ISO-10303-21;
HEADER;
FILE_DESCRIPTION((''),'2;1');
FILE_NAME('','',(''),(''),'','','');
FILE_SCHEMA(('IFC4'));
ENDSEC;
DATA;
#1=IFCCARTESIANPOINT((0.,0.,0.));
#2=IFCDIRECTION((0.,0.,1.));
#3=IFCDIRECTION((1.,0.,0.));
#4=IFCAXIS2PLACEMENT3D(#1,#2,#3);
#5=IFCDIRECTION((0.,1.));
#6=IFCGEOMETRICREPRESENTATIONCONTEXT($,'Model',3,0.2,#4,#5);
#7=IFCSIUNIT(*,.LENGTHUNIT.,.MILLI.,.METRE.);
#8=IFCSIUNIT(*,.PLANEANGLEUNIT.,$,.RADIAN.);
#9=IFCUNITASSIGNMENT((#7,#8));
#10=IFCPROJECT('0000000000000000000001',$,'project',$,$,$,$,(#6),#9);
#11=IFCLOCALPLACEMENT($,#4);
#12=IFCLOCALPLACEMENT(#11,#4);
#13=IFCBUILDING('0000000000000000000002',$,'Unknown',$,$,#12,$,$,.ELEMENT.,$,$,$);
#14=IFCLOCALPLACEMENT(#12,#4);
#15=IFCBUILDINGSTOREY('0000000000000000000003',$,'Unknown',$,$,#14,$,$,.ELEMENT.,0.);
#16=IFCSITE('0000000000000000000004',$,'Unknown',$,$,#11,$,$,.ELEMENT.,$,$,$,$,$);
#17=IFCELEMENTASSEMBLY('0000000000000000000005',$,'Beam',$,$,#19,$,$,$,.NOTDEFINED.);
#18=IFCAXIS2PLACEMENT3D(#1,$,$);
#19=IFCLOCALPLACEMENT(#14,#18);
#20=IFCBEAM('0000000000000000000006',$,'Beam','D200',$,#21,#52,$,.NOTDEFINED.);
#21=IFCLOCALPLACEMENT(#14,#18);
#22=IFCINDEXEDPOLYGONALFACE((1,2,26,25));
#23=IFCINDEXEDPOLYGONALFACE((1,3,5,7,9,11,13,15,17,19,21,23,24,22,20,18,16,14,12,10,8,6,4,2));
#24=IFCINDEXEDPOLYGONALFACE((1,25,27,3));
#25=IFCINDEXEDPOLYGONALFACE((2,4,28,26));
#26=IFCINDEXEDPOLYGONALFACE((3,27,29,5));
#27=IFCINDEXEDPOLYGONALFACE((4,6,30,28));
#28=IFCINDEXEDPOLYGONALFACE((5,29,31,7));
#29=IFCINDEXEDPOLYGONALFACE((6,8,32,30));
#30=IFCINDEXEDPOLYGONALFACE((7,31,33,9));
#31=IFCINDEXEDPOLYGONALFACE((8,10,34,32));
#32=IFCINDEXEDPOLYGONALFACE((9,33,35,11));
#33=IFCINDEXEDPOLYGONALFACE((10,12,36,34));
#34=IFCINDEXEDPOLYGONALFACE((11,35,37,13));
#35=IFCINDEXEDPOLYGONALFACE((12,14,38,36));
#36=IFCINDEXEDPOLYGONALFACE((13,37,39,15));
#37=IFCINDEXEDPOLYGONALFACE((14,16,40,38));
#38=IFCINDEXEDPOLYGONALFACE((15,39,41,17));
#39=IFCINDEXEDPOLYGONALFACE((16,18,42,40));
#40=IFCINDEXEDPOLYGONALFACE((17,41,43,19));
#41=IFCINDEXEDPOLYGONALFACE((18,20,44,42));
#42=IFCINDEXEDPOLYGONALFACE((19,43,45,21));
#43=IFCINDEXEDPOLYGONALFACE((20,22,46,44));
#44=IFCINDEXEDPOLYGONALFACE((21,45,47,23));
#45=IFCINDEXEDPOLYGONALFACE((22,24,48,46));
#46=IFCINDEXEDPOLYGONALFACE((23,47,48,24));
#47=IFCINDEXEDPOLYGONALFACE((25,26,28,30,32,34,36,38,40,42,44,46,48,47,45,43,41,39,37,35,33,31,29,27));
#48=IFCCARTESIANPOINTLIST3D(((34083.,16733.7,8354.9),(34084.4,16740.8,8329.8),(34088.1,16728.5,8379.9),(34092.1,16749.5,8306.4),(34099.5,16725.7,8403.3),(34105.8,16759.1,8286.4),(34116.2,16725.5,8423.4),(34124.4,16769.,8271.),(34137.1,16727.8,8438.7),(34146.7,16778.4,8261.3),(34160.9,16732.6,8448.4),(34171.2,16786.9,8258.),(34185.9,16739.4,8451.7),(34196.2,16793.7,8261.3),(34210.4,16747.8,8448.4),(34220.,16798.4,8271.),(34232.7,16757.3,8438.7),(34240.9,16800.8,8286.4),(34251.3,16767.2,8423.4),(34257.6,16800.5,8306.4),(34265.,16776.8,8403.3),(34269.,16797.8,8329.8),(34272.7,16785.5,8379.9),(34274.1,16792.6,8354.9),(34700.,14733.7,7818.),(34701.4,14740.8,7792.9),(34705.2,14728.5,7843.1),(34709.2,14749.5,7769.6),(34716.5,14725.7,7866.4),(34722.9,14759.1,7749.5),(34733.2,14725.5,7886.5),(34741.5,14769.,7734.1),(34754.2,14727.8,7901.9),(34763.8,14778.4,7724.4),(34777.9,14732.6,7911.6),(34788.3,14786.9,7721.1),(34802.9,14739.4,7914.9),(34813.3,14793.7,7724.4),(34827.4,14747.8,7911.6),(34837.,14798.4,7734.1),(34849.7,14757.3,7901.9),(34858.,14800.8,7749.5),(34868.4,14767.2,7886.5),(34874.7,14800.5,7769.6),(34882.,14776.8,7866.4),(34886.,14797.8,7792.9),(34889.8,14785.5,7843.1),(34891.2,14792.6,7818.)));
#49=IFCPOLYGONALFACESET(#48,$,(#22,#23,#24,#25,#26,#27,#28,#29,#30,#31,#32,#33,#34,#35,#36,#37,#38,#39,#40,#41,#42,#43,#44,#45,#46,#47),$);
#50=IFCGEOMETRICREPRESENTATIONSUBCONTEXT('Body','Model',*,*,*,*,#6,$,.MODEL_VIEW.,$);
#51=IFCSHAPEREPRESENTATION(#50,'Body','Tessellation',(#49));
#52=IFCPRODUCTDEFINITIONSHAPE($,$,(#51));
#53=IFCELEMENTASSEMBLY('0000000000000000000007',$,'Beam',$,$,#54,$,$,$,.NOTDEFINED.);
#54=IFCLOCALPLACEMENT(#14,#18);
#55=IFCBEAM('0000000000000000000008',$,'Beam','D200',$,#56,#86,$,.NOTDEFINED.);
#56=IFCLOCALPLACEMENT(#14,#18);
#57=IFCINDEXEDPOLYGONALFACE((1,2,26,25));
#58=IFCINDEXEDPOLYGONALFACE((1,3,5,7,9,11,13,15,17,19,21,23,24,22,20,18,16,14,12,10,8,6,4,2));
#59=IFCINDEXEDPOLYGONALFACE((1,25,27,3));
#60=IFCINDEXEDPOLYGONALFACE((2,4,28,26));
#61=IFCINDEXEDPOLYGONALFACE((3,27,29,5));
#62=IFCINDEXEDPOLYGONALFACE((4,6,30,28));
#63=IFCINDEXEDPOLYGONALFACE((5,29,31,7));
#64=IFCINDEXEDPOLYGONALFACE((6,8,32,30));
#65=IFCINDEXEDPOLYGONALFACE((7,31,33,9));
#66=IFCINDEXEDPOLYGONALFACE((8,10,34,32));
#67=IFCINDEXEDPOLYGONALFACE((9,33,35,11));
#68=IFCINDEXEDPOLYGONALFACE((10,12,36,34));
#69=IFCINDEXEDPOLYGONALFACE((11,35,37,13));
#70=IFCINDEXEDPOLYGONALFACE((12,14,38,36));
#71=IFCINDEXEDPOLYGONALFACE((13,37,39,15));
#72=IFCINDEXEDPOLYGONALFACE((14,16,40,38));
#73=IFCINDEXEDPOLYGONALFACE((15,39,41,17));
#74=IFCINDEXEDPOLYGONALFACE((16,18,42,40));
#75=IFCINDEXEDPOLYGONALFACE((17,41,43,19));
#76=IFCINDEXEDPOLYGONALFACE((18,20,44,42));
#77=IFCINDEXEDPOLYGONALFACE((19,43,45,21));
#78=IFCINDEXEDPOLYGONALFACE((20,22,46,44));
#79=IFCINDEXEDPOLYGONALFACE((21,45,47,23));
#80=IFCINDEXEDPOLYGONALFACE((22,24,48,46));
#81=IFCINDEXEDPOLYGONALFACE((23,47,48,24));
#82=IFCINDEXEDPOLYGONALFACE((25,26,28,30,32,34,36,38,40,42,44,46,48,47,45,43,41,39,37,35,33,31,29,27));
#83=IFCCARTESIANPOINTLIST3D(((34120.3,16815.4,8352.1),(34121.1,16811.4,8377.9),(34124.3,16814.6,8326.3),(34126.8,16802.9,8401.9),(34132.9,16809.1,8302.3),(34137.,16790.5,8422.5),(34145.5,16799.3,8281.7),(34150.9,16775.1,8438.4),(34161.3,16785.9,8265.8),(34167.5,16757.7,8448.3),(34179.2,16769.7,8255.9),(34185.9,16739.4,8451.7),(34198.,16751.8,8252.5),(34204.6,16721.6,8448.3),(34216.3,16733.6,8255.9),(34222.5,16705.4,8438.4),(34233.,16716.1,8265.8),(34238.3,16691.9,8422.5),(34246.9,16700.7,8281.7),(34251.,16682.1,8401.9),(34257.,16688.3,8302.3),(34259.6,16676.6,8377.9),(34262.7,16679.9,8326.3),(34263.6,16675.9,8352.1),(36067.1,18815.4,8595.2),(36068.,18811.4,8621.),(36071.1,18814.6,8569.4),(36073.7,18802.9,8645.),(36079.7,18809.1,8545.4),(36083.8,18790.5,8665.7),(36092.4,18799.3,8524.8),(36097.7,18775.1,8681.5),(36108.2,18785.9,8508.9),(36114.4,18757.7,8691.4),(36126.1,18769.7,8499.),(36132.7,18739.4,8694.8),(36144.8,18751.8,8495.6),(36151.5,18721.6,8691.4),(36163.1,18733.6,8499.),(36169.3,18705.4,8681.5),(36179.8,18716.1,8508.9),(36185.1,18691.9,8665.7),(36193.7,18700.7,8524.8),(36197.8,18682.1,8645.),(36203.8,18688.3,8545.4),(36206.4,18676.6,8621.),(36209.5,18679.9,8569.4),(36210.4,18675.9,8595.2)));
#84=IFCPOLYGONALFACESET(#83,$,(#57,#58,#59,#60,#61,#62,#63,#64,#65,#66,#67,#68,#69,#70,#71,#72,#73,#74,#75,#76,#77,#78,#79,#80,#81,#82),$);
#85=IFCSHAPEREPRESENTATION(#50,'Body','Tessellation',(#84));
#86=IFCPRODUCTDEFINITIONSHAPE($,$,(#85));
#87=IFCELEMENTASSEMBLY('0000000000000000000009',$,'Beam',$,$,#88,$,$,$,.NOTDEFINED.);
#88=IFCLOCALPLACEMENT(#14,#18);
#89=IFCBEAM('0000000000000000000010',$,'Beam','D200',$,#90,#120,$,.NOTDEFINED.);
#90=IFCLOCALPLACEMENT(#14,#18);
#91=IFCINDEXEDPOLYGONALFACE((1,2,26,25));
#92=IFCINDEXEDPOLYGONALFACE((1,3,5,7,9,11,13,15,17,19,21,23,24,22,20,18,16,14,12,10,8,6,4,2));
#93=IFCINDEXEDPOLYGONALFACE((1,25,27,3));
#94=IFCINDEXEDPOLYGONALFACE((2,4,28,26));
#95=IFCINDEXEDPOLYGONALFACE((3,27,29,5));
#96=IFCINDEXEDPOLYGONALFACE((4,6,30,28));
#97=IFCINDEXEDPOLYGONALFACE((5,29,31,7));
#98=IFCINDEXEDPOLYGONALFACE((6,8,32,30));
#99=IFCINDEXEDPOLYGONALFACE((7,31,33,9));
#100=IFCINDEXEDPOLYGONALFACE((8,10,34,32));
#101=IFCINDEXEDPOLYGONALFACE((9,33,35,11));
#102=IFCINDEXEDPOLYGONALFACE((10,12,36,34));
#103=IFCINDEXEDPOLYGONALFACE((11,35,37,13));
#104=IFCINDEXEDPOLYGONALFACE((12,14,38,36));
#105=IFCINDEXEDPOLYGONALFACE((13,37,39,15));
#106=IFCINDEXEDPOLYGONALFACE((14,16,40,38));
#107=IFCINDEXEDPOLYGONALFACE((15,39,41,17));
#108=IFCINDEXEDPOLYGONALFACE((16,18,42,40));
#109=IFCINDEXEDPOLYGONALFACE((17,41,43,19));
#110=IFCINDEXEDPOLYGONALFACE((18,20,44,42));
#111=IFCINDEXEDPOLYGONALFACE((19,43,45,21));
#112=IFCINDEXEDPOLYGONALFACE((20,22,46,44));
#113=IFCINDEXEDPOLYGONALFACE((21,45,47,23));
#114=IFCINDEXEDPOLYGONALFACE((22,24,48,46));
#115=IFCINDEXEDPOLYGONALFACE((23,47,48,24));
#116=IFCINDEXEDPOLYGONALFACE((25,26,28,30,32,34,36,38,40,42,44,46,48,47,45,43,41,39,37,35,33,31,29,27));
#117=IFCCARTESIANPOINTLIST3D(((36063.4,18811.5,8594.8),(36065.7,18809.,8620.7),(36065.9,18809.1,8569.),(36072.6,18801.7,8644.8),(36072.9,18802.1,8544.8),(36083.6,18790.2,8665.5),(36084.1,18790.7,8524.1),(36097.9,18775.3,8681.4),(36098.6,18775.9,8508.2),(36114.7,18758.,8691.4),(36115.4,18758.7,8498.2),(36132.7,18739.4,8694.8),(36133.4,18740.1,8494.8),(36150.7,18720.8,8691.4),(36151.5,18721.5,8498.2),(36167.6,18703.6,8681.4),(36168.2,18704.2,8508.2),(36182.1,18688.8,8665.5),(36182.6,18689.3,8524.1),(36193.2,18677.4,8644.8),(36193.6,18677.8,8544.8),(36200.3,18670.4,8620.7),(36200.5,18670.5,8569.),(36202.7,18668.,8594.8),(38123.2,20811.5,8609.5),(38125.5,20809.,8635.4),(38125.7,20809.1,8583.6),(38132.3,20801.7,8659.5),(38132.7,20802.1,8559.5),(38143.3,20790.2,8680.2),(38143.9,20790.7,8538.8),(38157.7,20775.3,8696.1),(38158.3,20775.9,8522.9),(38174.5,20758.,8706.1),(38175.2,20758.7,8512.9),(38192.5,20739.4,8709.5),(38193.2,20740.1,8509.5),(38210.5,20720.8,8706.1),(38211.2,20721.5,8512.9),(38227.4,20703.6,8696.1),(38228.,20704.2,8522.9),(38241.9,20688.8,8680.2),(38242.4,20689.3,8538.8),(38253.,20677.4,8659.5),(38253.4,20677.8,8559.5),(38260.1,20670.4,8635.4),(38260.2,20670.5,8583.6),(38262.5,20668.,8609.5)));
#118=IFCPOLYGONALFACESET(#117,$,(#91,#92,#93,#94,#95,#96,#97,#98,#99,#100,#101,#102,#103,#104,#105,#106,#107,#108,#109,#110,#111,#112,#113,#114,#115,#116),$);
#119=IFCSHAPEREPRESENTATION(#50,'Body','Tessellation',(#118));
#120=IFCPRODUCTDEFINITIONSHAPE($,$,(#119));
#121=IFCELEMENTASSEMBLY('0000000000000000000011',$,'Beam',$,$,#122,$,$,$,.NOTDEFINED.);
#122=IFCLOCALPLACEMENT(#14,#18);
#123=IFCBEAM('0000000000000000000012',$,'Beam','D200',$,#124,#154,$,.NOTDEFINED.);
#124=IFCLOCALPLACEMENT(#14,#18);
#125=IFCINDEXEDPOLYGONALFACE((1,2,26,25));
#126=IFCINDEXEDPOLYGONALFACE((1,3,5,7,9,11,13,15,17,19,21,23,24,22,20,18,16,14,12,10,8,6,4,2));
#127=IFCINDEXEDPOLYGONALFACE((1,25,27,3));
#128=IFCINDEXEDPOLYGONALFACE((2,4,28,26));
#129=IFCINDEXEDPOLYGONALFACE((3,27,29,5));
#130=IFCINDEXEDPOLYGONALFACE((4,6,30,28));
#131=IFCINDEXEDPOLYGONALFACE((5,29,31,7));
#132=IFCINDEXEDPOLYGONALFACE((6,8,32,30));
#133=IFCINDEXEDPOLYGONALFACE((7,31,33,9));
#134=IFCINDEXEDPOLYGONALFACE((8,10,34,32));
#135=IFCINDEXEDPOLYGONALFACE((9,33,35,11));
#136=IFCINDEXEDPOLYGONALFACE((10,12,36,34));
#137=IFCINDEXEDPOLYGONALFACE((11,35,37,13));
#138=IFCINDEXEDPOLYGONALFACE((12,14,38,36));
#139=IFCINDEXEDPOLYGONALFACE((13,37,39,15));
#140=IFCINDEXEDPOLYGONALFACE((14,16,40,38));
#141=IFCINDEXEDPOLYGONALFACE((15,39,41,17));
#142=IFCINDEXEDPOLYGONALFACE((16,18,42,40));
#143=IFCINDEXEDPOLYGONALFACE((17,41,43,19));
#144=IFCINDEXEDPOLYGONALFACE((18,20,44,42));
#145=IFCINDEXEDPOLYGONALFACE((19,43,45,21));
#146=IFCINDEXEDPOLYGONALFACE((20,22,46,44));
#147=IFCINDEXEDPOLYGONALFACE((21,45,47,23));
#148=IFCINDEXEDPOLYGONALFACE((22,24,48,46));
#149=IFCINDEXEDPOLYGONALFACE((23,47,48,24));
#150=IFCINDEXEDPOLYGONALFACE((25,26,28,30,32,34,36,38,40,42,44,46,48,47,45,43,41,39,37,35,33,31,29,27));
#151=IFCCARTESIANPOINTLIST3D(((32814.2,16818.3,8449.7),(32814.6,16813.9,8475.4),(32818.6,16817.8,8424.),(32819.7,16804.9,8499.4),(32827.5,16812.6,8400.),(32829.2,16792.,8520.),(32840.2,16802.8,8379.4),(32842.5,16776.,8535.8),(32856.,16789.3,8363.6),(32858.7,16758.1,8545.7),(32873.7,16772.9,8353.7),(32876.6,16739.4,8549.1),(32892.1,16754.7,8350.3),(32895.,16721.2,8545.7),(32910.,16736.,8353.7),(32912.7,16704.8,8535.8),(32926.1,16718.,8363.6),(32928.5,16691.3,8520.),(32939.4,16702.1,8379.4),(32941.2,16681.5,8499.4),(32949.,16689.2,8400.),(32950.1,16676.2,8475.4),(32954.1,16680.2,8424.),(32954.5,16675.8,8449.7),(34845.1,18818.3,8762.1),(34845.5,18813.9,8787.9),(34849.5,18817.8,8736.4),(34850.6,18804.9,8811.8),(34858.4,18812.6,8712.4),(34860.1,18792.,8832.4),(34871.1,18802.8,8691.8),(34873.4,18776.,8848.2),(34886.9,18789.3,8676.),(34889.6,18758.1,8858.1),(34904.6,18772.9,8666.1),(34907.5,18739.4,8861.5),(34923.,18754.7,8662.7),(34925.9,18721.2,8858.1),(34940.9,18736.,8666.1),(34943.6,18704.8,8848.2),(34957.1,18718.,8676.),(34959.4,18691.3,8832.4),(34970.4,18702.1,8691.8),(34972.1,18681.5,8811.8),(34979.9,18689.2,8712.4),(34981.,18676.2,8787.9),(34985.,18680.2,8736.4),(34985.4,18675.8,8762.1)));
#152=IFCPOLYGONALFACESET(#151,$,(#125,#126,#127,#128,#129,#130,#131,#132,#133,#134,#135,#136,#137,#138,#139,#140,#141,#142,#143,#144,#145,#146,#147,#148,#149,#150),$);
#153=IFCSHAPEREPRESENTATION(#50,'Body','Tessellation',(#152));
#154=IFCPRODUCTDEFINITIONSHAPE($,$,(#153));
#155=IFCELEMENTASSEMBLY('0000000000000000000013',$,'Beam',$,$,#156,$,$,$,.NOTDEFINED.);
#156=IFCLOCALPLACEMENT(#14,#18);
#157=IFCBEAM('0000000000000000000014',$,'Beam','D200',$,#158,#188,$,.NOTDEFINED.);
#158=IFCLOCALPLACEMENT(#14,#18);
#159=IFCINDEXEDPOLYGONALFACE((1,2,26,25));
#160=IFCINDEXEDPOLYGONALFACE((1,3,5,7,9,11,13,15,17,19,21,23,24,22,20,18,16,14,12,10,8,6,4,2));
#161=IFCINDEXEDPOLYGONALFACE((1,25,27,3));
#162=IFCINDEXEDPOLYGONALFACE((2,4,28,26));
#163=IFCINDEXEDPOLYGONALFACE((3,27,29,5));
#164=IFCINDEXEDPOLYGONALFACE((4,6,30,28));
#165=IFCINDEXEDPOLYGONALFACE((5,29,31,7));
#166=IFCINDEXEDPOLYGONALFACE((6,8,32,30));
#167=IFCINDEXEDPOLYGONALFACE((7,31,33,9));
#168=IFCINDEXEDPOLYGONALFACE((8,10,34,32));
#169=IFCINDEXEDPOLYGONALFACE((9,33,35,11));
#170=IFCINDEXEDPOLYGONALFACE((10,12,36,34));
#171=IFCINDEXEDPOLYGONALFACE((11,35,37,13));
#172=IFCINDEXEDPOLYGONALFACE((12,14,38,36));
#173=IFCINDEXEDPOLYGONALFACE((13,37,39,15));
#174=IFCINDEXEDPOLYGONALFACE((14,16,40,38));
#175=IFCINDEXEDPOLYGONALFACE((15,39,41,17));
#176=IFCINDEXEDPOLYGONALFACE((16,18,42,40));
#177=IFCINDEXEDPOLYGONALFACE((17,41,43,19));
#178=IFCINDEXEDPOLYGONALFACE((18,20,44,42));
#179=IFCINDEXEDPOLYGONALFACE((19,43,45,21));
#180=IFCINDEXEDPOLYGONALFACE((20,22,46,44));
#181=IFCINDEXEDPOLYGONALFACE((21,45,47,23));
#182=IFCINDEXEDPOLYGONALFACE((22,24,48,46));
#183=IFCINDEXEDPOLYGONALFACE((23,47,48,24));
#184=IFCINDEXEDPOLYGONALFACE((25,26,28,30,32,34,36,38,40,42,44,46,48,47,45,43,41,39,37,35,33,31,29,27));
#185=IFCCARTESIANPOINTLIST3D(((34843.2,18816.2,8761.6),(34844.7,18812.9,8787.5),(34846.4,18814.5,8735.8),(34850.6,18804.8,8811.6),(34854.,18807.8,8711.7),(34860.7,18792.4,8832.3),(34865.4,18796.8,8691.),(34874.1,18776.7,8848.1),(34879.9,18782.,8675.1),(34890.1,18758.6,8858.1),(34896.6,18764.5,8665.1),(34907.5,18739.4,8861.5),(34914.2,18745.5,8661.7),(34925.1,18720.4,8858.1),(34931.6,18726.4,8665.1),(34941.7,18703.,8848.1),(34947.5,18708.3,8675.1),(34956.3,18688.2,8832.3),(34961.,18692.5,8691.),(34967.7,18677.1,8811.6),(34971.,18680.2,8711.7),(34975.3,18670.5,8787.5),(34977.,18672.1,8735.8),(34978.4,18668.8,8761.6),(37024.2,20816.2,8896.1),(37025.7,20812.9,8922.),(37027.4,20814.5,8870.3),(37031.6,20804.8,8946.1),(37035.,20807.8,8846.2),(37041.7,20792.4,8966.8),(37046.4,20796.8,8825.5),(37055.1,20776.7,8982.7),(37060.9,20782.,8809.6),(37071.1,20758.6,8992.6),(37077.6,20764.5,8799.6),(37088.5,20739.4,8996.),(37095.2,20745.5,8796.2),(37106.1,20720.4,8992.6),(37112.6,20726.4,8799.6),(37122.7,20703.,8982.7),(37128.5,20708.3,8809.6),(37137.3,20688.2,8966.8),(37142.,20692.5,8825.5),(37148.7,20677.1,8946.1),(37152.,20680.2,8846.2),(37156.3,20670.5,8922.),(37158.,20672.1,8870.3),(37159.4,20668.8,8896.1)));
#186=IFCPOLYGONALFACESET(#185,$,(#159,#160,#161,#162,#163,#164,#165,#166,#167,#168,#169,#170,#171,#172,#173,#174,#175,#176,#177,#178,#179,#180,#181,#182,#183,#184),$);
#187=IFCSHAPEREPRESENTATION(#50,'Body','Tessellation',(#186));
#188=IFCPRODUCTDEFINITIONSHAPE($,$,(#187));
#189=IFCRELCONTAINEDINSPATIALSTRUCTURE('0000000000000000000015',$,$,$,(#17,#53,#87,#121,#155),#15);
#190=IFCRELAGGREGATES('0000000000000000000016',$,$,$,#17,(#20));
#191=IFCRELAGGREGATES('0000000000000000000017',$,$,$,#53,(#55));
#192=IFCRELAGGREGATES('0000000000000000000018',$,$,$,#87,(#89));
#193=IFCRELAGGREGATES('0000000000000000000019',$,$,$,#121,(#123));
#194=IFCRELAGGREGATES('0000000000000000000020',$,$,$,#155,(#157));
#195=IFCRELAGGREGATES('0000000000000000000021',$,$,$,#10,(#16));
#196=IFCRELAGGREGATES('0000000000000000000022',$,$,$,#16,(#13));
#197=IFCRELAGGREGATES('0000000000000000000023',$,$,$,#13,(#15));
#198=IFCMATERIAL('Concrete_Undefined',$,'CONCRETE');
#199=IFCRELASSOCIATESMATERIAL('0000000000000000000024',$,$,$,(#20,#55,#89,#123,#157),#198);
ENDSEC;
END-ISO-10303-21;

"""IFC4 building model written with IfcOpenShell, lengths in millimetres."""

from ifc_helpers import new_model, si_unit, direction, frame, origin_with_axes, place, context, subcontext, project, spatial, line, indexed_curve, outline, extrude, material, element, aggregate, save


model = new_model("IFC4")

# Units and contexts
model_context = context("Model", 3, precision=0.2, world=origin_with_axes(), true_north=direction((0.0, 1.0)))
body_context = subcontext(model_context, "Body", "Model", "MODEL_VIEW")
ifc_project = project(units=[si_unit("LENGTHUNIT", "METRE", prefix="MILLI"), si_unit("PLANEANGLEUNIT", "RADIAN")], contexts=[model_context])

# Site, building, storey
site_placement = place(None, origin_with_axes())
site = spatial("IfcSite", under=ifc_project, at=site_placement, Name="Unknown", CompositionType="ELEMENT")
building_placement = place(site_placement, origin_with_axes())
building = spatial("IfcBuilding", under=site, at=building_placement, Name="Unknown", CompositionType="ELEMENT")
storey_placement = place(building_placement, origin_with_axes())
storey = spatial("IfcBuildingStorey", under=building, at=storey_placement, Name="Unknown", CompositionType="ELEMENT", Elevation=0.0)

# Element assemblies, beams
ifc_material = material(Name="Concrete_Undefined", Category="CONCRETE")
assembly_1_placement = place(storey_placement, frame((34178.6, 16763.1, 8354.9), z_axis=(-0.955555, -0.294814, 0.0), x_axis=(0.28557, -0.925591, -0.248458)))
assembly_1 = element("IfcElementAssembly", 1, at=assembly_1_placement, inside=storey, Name="Beam", PredefinedType="NOTDEFINED")
beam_1_placement = place(assembly_1_placement, origin_with_axes())
beam_1 = element("IfcBeam", 2, at=beam_1_placement, material=ifc_material, Name="Beam", Description="D200", PredefinedType="NOTDEFINED", context=body_context, shape_type="SolidModel", body=[
    extrude(outline(indexed_curve([(100.0, 0.0), (96.6, 25.9), (86.6, 50.0), (70.7, 70.7), (50.0, 86.6), (25.9, 96.6), (0.0, 100.0), (-25.9, 96.6), (-50.0, 86.6), (-70.7, 70.7), (-86.6, 50.0), (-96.6, 25.9), (-100.0, 0.0), (-96.6, -25.9), (-86.6, -50.0), (-70.7, -70.7), (-50.0, -86.6), (-25.9, -96.6), (0.0, -100.0), (25.9, -96.6), (50.0, -86.6), (70.7, -70.7), (86.6, -50.0), (96.6, -25.9)], segments=[line(1, 2, 3, 4, 5, 6, 7, 8, 9, 10, 11, 12, 13, 14, 15, 16, 17, 18, 19, 20, 21, 22, 23, 24, 1)])), frame((0.0, 0.0, 0.0), z_axis=(-1.0, 0.0, 0.0), x_axis=(0.0, 0.0, 1.0)), (0.0, 0.0, -1.0), 2160.8),
])
aggregate(assembly_1, [beam_1])
assembly_2_placement = place(storey_placement, frame((36138.8, 18745.6, 8595.2), z_axis=(-0.716568, 0.697517, 0.0), x_axis=(-0.694886, -0.713866, -0.086774)))
assembly_2 = element("IfcElementAssembly", 3, at=assembly_2_placement, inside=storey, Name="Beam", PredefinedType="NOTDEFINED")
beam_2_placement = place(assembly_2_placement, origin_with_axes())
beam_2 = element("IfcBeam", 4, at=beam_2_placement, material=ifc_material, Name="Beam", Description="D200", PredefinedType="NOTDEFINED", context=body_context, shape_type="SolidModel", body=[
    extrude(outline(indexed_curve([(100.0, 0.0), (96.6, 25.9), (86.6, 50.0), (70.7, 70.7), (50.0, 86.6), (25.9, 96.6), (0.0, 100.0), (-25.9, 96.6), (-50.0, 86.6), (-70.7, 70.7), (-86.6, 50.0), (-96.6, 25.9), (-100.0, 0.0), (-96.6, -25.9), (-86.6, -50.0), (-70.7, -70.7), (-50.0, -86.6), (-25.9, -96.6), (0.0, -100.0), (25.9, -96.6), (50.0, -86.6), (70.7, -70.7), (86.6, -50.0), (96.6, -25.9)], segments=[line(1, 2, 3, 4, 5, 6, 7, 8, 9, 10, 11, 12, 13, 14, 15, 16, 17, 18, 19, 20, 21, 22, 23, 24, 1)])), frame((0.0, 0.0, 0.0), z_axis=(-1.0, 0.0, 0.0), x_axis=(0.0, 0.0, 1.0)), (0.0, 0.0, -1.0), 2801.6),
])
aggregate(assembly_2, [beam_2])
assembly_3_placement = place(storey_placement, frame((38192.9, 20739.8, 8609.5), z_axis=(-0.696617, 0.717443, 0.0), x_axis=(-0.717434, -0.696608, -0.005114)))
assembly_3 = element("IfcElementAssembly", 5, at=assembly_3_placement, inside=storey, Name="Beam", PredefinedType="NOTDEFINED")
beam_3_placement = place(assembly_3_placement, origin_with_axes())
beam_3 = element("IfcBeam", 6, at=beam_3_placement, material=ifc_material, Name="Beam", Description="D200", PredefinedType="NOTDEFINED", context=body_context, shape_type="SolidModel", body=[
    extrude(outline(indexed_curve([(100.0, 0.0), (96.6, 25.9), (86.6, 50.0), (70.7, 70.7), (50.0, 86.6), (25.9, 96.6), (0.0, 100.0), (-25.9, 96.6), (-50.0, 86.6), (-70.7, 70.7), (-86.6, 50.0), (-96.6, 25.9), (-100.0, 0.0), (-96.6, -25.9), (-86.6, -50.0), (-70.7, -70.7), (-50.0, -86.6), (-25.9, -96.6), (0.0, -100.0), (25.9, -96.6), (50.0, -86.6), (70.7, -70.7), (86.6, -50.0), (96.6, -25.9)], segments=[line(1, 2, 3, 4, 5, 6, 7, 8, 9, 10, 11, 12, 13, 14, 15, 16, 17, 18, 19, 20, 21, 22, 23, 24, 1)])), frame((0.0, 0.0, 0.0), z_axis=(-1.0, 0.0, 0.0), x_axis=(0.0, 0.0, 1.0)), (0.0, 0.0, -1.0), 2871.1),
])
aggregate(assembly_3, [beam_3])
assembly_4_placement = place(storey_placement, frame((34915.3, 18747.0, 8762.1), z_axis=(-0.701663, 0.712509, 0.0), x_axis=(-0.708267, -0.697486, -0.108952)))
assembly_4 = element("IfcElementAssembly", 7, at=assembly_4_placement, inside=storey, Name="Beam", PredefinedType="NOTDEFINED")
beam_4_placement = place(assembly_4_placement, origin_with_axes())
beam_4 = element("IfcBeam", 8, at=beam_4_placement, material=ifc_material, Name="Beam", Description="D200", PredefinedType="NOTDEFINED", context=body_context, shape_type="SolidModel", body=[
    extrude(outline(indexed_curve([(100.0, 0.0), (96.6, 25.9), (86.6, 50.0), (70.7, 70.7), (50.0, 86.6), (25.9, 96.6), (0.0, 100.0), (-25.9, 96.6), (-50.0, 86.6), (-70.7, 70.7), (-86.6, 50.0), (-96.6, 25.9), (-100.0, 0.0), (-96.6, -25.9), (-86.6, -50.0), (-70.7, -70.7), (-50.0, -86.6), (-25.9, -96.6), (0.0, -100.0), (25.9, -96.6), (50.0, -86.6), (70.7, -70.7), (86.6, -50.0), (96.6, -25.9)], segments=[line(1, 2, 3, 4, 5, 6, 7, 8, 9, 10, 11, 12, 13, 14, 15, 16, 17, 18, 19, 20, 21, 22, 23, 24, 1)])), frame((0.0, 0.0, 0.0), z_axis=(-1.0, 0.0, 0.0), x_axis=(0.0, 0.0, 1.0)), (0.0, 0.0, -1.0), 2867.4),
])
aggregate(assembly_4, [beam_4])
assembly_5_placement = place(storey_placement, frame((37091.8, 20742.5, 8896.1), z_axis=(-0.675863, 0.737028, 0.0), x_axis=(-0.736267, -0.675166, -0.045407)))
assembly_5 = element("IfcElementAssembly", 9, at=assembly_5_placement, inside=storey, Name="Beam", PredefinedType="NOTDEFINED")
beam_5_placement = place(assembly_5_placement, origin_with_axes())
beam_5 = element("IfcBeam", 10, at=beam_5_placement, material=ifc_material, Name="Beam", Description="D200", PredefinedType="NOTDEFINED", context=body_context, shape_type="SolidModel", body=[
    extrude(outline(indexed_curve([(100.0, 0.0), (96.6, 25.9), (86.6, 50.0), (70.7, 70.7), (50.0, 86.6), (25.9, 96.6), (0.0, 100.0), (-25.9, 96.6), (-50.0, 86.6), (-70.7, 70.7), (-86.6, 50.0), (-96.6, 25.9), (-100.0, 0.0), (-96.6, -25.9), (-86.6, -50.0), (-70.7, -70.7), (-50.0, -86.6), (-25.9, -96.6), (0.0, -100.0), (25.9, -96.6), (50.0, -86.6), (70.7, -70.7), (86.6, -50.0), (96.6, -25.9)], segments=[line(1, 2, 3, 4, 5, 6, 7, 8, 9, 10, 11, 12, 13, 14, 15, 16, 17, 18, 19, 20, 21, 22, 23, 24, 1)])), frame((0.0, 0.0, 0.0), z_axis=(-1.0, 0.0, 0.0), x_axis=(0.0, 0.0, 1.0)), (0.0, 0.0, -1.0), 2962.2),
])
aggregate(assembly_5, [beam_5])

save(model, "model.ifc")
